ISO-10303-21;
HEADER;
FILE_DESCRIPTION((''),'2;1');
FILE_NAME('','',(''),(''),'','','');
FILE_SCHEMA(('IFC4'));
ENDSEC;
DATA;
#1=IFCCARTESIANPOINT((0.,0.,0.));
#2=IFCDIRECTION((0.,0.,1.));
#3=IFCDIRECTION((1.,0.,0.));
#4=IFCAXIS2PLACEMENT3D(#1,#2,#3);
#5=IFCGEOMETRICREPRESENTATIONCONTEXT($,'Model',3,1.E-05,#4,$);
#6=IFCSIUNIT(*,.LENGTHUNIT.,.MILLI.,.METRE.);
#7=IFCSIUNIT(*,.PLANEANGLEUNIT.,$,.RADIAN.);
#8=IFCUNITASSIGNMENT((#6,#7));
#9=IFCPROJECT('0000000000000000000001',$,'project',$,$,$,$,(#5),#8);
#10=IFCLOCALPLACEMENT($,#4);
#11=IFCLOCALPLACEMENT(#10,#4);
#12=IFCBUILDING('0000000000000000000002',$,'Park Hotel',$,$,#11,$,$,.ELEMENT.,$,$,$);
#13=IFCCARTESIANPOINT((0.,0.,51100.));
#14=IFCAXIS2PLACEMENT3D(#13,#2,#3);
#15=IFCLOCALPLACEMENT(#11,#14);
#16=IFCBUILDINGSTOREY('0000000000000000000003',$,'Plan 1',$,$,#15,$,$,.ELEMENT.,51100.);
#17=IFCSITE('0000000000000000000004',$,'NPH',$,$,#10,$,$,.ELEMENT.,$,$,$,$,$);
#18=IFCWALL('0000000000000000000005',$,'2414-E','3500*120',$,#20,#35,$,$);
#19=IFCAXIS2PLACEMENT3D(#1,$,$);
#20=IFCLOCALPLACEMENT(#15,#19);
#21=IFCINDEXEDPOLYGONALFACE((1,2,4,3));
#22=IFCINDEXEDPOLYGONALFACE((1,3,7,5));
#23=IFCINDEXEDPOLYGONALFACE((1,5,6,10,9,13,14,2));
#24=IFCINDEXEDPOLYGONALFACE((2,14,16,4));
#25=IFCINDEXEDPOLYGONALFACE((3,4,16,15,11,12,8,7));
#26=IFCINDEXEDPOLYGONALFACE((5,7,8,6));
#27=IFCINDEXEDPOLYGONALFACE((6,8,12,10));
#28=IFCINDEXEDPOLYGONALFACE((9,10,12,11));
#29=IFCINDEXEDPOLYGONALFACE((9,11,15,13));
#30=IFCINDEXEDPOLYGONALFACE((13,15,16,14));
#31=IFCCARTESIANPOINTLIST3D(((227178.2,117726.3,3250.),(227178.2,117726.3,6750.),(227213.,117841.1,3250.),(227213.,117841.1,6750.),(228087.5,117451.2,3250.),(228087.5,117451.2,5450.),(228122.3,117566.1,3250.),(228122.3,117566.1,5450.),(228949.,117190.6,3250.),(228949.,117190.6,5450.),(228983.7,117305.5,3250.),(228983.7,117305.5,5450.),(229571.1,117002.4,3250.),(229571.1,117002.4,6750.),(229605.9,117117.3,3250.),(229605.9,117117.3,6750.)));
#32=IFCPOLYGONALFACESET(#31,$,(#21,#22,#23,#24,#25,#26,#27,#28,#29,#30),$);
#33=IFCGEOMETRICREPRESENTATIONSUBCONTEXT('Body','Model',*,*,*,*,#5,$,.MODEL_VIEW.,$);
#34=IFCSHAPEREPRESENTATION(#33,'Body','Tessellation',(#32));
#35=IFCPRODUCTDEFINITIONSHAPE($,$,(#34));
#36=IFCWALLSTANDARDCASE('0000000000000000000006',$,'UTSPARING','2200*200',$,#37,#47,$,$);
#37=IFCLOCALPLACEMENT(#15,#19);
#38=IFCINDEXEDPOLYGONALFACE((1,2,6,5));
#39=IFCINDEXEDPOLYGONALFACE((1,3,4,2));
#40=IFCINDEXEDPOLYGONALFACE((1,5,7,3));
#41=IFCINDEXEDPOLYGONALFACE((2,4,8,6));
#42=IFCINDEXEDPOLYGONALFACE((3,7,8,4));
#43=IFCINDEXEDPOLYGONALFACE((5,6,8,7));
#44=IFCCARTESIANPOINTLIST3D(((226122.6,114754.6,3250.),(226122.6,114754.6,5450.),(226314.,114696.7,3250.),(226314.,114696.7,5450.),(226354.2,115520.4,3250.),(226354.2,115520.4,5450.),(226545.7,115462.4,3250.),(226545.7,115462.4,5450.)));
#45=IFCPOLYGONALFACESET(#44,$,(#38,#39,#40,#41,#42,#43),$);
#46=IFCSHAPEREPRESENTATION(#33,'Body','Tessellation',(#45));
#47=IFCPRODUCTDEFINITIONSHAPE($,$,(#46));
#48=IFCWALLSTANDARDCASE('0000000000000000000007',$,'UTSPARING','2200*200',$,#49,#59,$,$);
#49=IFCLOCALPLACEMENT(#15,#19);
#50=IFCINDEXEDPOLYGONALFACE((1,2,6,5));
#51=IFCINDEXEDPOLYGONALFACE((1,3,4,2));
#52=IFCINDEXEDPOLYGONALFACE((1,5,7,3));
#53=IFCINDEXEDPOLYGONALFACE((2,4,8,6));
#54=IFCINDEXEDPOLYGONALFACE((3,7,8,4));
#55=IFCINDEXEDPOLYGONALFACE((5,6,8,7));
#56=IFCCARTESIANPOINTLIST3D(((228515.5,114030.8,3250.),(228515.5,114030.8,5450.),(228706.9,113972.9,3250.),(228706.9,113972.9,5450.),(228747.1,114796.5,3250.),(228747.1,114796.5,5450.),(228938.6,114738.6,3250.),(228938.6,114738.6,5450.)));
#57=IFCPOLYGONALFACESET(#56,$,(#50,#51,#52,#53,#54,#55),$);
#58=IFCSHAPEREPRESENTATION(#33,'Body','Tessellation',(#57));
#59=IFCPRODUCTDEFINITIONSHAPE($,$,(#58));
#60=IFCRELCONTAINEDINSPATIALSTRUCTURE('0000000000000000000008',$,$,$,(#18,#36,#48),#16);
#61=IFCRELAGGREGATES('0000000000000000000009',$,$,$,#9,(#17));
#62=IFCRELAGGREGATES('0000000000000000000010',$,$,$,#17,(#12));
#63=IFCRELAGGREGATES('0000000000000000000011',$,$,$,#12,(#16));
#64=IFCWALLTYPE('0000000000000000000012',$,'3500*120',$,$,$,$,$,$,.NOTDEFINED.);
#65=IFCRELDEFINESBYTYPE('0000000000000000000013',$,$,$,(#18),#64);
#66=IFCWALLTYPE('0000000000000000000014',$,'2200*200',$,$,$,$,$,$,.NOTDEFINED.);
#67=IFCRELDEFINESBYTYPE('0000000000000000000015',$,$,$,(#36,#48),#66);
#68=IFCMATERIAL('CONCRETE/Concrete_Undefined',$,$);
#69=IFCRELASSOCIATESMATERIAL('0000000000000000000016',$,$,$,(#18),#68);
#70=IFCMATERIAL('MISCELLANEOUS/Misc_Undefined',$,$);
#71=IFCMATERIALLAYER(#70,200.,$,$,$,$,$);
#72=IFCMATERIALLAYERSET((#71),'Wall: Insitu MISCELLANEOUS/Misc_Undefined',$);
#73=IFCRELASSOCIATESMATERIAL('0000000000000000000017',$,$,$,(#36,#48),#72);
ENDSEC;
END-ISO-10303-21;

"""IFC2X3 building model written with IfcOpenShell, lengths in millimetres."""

from ifc_helpers import new_model, si_unit, frame, frame_2d, origin_with_axes, place, context, subcontext, project, spatial, rectangle, extrude, boolean, material, layer, layer_set, layer_usage, type_object, element, save


model = new_model("IFC2X3")

# Units and contexts
model_context = context("Model", 3, precision=1e-05, world=origin_with_axes())
body_context = subcontext(model_context, "Body", "Model", "MODEL_VIEW")
ifc_project = project(units=[si_unit("LENGTHUNIT", "METRE", prefix="MILLI"), si_unit("PLANEANGLEUNIT", "RADIAN")], contexts=[model_context])

# Site, building, storey
site_placement = place(None, origin_with_axes())
site = spatial("IfcSite", under=ifc_project, at=site_placement, Name="NPH", CompositionType="ELEMENT")
building_placement = place(site_placement, origin_with_axes())
building = spatial("IfcBuilding", under=site, at=building_placement, Name="Park Hotel", CompositionType="ELEMENT")
storey_placement = place(building_placement, frame((0.0, 0.0, 51100.0), z_axis=(0.0, 0.0, 1.0), x_axis=(1.0, 0.0, 0.0)))
storey = spatial("IfcBuildingStorey", under=building, at=storey_placement, Name="Plan 1", CompositionType="ELEMENT", Elevation=51100.0)

# Shared definitions
ifc_material_1 = material(Name="CONCRETE/Concrete_Undefined")

# Walls
ifc_material_2 = material(Name="MISCELLANEOUS/Misc_Undefined")
ifc_layer_1 = layer(ifc_material_2, 200.0)
ifc_layer_set_1 = layer_set([ifc_layer_1], Name="Wall: Insitu MISCELLANEOUS/Misc_Undefined")
wall_type_1 = type_object("IfcWallType", Name="3500*120", PredefinedType="NOTDEFINED")
wall_1_placement = place(storey_placement, frame((229588.5, 117059.9, 3250.0), z_axis=(0.0, 0.0, 1.0), x_axis=(-0.957166, 0.289539, 0.0)))
element("IfcWall", 1, at=wall_1_placement, inside=storey, type_object=wall_type_1, material=ifc_material_1, Name="2414-E", Description="3500*120", context=body_context, shape_type="CSG", body=[
    boolean("DIFFERENCE", extrude(rectangle(XDim=2500.0, YDim=120.0, at=frame_2d((0.0, 1250.0), x_axis=(0.0, -1.0))), frame((0.0, 0.0, 0.0), z_axis=(0.0, 0.0, 1.0), x_axis=(0.0, -1.0, 0.0)), (0.0, 0.0, 1.0), 3500.0), extrude(rectangle(XDim=900.0, YDim=150.0, at=frame_2d((0.0, 450.0), x_axis=(0.0, -1.0))), frame((650.0, -15.0, 0.0), z_axis=(0.0, 0.0, 1.0), x_axis=(-0.000003, -1.0, 0.0)), (0.0, 0.0, 1.0), 2200.0)),
])
ifc_layer_usage_1 = layer_usage(ifc_layer_set_1, "AXIS2", "POSITIVE", -100.0)
wall_type_2 = type_object("IfcWallType", Name="2200*200", PredefinedType="NOTDEFINED")
wall_2_placement = place(storey_placement, frame((226449.9, 115491.4, 3250.0), z_axis=(0.0, 0.0, 1.0), x_axis=(-0.289542, -0.957165, 0.0)))
element("IfcWallStandardCase", 2, at=wall_2_placement, inside=storey, type_object=wall_type_2, material=ifc_layer_usage_1, Name="UTSPARING", Description="2200*200", context=body_context, shape_type="SweptSolid", body=[
    extrude(rectangle(XDim=800.0, YDim=200.0, at=frame_2d((0.0, 400.0), x_axis=(0.0, -1.0))), frame((0.0, 0.0, 0.0), z_axis=(0.0, 0.0, 1.0), x_axis=(0.0, -1.0, 0.0)), (0.0, 0.0, 1.0), 2200.0),
])
ifc_layer_usage_2 = layer_usage(ifc_layer_set_1, "AXIS2", "POSITIVE", -100.0)
wall_3_placement = place(storey_placement, frame((228842.9, 114767.6, 3250.0), z_axis=(0.0, 0.0, 1.0), x_axis=(-0.289542, -0.957165, 0.0)))
element("IfcWallStandardCase", 3, at=wall_3_placement, inside=storey, type_object=wall_type_2, material=ifc_layer_usage_2, Name="UTSPARING", Description="2200*200", context=body_context, shape_type="SweptSolid", body=[
    extrude(rectangle(XDim=800.0, YDim=200.0, at=frame_2d((0.0, 400.0), x_axis=(0.0, -1.0))), frame((0.0, 0.0, 0.0), z_axis=(0.0, 0.0, 1.0), x_axis=(0.0, -1.0, 0.0)), (0.0, 0.0, 1.0), 2200.0),
])

save(model, "model.ifc")
